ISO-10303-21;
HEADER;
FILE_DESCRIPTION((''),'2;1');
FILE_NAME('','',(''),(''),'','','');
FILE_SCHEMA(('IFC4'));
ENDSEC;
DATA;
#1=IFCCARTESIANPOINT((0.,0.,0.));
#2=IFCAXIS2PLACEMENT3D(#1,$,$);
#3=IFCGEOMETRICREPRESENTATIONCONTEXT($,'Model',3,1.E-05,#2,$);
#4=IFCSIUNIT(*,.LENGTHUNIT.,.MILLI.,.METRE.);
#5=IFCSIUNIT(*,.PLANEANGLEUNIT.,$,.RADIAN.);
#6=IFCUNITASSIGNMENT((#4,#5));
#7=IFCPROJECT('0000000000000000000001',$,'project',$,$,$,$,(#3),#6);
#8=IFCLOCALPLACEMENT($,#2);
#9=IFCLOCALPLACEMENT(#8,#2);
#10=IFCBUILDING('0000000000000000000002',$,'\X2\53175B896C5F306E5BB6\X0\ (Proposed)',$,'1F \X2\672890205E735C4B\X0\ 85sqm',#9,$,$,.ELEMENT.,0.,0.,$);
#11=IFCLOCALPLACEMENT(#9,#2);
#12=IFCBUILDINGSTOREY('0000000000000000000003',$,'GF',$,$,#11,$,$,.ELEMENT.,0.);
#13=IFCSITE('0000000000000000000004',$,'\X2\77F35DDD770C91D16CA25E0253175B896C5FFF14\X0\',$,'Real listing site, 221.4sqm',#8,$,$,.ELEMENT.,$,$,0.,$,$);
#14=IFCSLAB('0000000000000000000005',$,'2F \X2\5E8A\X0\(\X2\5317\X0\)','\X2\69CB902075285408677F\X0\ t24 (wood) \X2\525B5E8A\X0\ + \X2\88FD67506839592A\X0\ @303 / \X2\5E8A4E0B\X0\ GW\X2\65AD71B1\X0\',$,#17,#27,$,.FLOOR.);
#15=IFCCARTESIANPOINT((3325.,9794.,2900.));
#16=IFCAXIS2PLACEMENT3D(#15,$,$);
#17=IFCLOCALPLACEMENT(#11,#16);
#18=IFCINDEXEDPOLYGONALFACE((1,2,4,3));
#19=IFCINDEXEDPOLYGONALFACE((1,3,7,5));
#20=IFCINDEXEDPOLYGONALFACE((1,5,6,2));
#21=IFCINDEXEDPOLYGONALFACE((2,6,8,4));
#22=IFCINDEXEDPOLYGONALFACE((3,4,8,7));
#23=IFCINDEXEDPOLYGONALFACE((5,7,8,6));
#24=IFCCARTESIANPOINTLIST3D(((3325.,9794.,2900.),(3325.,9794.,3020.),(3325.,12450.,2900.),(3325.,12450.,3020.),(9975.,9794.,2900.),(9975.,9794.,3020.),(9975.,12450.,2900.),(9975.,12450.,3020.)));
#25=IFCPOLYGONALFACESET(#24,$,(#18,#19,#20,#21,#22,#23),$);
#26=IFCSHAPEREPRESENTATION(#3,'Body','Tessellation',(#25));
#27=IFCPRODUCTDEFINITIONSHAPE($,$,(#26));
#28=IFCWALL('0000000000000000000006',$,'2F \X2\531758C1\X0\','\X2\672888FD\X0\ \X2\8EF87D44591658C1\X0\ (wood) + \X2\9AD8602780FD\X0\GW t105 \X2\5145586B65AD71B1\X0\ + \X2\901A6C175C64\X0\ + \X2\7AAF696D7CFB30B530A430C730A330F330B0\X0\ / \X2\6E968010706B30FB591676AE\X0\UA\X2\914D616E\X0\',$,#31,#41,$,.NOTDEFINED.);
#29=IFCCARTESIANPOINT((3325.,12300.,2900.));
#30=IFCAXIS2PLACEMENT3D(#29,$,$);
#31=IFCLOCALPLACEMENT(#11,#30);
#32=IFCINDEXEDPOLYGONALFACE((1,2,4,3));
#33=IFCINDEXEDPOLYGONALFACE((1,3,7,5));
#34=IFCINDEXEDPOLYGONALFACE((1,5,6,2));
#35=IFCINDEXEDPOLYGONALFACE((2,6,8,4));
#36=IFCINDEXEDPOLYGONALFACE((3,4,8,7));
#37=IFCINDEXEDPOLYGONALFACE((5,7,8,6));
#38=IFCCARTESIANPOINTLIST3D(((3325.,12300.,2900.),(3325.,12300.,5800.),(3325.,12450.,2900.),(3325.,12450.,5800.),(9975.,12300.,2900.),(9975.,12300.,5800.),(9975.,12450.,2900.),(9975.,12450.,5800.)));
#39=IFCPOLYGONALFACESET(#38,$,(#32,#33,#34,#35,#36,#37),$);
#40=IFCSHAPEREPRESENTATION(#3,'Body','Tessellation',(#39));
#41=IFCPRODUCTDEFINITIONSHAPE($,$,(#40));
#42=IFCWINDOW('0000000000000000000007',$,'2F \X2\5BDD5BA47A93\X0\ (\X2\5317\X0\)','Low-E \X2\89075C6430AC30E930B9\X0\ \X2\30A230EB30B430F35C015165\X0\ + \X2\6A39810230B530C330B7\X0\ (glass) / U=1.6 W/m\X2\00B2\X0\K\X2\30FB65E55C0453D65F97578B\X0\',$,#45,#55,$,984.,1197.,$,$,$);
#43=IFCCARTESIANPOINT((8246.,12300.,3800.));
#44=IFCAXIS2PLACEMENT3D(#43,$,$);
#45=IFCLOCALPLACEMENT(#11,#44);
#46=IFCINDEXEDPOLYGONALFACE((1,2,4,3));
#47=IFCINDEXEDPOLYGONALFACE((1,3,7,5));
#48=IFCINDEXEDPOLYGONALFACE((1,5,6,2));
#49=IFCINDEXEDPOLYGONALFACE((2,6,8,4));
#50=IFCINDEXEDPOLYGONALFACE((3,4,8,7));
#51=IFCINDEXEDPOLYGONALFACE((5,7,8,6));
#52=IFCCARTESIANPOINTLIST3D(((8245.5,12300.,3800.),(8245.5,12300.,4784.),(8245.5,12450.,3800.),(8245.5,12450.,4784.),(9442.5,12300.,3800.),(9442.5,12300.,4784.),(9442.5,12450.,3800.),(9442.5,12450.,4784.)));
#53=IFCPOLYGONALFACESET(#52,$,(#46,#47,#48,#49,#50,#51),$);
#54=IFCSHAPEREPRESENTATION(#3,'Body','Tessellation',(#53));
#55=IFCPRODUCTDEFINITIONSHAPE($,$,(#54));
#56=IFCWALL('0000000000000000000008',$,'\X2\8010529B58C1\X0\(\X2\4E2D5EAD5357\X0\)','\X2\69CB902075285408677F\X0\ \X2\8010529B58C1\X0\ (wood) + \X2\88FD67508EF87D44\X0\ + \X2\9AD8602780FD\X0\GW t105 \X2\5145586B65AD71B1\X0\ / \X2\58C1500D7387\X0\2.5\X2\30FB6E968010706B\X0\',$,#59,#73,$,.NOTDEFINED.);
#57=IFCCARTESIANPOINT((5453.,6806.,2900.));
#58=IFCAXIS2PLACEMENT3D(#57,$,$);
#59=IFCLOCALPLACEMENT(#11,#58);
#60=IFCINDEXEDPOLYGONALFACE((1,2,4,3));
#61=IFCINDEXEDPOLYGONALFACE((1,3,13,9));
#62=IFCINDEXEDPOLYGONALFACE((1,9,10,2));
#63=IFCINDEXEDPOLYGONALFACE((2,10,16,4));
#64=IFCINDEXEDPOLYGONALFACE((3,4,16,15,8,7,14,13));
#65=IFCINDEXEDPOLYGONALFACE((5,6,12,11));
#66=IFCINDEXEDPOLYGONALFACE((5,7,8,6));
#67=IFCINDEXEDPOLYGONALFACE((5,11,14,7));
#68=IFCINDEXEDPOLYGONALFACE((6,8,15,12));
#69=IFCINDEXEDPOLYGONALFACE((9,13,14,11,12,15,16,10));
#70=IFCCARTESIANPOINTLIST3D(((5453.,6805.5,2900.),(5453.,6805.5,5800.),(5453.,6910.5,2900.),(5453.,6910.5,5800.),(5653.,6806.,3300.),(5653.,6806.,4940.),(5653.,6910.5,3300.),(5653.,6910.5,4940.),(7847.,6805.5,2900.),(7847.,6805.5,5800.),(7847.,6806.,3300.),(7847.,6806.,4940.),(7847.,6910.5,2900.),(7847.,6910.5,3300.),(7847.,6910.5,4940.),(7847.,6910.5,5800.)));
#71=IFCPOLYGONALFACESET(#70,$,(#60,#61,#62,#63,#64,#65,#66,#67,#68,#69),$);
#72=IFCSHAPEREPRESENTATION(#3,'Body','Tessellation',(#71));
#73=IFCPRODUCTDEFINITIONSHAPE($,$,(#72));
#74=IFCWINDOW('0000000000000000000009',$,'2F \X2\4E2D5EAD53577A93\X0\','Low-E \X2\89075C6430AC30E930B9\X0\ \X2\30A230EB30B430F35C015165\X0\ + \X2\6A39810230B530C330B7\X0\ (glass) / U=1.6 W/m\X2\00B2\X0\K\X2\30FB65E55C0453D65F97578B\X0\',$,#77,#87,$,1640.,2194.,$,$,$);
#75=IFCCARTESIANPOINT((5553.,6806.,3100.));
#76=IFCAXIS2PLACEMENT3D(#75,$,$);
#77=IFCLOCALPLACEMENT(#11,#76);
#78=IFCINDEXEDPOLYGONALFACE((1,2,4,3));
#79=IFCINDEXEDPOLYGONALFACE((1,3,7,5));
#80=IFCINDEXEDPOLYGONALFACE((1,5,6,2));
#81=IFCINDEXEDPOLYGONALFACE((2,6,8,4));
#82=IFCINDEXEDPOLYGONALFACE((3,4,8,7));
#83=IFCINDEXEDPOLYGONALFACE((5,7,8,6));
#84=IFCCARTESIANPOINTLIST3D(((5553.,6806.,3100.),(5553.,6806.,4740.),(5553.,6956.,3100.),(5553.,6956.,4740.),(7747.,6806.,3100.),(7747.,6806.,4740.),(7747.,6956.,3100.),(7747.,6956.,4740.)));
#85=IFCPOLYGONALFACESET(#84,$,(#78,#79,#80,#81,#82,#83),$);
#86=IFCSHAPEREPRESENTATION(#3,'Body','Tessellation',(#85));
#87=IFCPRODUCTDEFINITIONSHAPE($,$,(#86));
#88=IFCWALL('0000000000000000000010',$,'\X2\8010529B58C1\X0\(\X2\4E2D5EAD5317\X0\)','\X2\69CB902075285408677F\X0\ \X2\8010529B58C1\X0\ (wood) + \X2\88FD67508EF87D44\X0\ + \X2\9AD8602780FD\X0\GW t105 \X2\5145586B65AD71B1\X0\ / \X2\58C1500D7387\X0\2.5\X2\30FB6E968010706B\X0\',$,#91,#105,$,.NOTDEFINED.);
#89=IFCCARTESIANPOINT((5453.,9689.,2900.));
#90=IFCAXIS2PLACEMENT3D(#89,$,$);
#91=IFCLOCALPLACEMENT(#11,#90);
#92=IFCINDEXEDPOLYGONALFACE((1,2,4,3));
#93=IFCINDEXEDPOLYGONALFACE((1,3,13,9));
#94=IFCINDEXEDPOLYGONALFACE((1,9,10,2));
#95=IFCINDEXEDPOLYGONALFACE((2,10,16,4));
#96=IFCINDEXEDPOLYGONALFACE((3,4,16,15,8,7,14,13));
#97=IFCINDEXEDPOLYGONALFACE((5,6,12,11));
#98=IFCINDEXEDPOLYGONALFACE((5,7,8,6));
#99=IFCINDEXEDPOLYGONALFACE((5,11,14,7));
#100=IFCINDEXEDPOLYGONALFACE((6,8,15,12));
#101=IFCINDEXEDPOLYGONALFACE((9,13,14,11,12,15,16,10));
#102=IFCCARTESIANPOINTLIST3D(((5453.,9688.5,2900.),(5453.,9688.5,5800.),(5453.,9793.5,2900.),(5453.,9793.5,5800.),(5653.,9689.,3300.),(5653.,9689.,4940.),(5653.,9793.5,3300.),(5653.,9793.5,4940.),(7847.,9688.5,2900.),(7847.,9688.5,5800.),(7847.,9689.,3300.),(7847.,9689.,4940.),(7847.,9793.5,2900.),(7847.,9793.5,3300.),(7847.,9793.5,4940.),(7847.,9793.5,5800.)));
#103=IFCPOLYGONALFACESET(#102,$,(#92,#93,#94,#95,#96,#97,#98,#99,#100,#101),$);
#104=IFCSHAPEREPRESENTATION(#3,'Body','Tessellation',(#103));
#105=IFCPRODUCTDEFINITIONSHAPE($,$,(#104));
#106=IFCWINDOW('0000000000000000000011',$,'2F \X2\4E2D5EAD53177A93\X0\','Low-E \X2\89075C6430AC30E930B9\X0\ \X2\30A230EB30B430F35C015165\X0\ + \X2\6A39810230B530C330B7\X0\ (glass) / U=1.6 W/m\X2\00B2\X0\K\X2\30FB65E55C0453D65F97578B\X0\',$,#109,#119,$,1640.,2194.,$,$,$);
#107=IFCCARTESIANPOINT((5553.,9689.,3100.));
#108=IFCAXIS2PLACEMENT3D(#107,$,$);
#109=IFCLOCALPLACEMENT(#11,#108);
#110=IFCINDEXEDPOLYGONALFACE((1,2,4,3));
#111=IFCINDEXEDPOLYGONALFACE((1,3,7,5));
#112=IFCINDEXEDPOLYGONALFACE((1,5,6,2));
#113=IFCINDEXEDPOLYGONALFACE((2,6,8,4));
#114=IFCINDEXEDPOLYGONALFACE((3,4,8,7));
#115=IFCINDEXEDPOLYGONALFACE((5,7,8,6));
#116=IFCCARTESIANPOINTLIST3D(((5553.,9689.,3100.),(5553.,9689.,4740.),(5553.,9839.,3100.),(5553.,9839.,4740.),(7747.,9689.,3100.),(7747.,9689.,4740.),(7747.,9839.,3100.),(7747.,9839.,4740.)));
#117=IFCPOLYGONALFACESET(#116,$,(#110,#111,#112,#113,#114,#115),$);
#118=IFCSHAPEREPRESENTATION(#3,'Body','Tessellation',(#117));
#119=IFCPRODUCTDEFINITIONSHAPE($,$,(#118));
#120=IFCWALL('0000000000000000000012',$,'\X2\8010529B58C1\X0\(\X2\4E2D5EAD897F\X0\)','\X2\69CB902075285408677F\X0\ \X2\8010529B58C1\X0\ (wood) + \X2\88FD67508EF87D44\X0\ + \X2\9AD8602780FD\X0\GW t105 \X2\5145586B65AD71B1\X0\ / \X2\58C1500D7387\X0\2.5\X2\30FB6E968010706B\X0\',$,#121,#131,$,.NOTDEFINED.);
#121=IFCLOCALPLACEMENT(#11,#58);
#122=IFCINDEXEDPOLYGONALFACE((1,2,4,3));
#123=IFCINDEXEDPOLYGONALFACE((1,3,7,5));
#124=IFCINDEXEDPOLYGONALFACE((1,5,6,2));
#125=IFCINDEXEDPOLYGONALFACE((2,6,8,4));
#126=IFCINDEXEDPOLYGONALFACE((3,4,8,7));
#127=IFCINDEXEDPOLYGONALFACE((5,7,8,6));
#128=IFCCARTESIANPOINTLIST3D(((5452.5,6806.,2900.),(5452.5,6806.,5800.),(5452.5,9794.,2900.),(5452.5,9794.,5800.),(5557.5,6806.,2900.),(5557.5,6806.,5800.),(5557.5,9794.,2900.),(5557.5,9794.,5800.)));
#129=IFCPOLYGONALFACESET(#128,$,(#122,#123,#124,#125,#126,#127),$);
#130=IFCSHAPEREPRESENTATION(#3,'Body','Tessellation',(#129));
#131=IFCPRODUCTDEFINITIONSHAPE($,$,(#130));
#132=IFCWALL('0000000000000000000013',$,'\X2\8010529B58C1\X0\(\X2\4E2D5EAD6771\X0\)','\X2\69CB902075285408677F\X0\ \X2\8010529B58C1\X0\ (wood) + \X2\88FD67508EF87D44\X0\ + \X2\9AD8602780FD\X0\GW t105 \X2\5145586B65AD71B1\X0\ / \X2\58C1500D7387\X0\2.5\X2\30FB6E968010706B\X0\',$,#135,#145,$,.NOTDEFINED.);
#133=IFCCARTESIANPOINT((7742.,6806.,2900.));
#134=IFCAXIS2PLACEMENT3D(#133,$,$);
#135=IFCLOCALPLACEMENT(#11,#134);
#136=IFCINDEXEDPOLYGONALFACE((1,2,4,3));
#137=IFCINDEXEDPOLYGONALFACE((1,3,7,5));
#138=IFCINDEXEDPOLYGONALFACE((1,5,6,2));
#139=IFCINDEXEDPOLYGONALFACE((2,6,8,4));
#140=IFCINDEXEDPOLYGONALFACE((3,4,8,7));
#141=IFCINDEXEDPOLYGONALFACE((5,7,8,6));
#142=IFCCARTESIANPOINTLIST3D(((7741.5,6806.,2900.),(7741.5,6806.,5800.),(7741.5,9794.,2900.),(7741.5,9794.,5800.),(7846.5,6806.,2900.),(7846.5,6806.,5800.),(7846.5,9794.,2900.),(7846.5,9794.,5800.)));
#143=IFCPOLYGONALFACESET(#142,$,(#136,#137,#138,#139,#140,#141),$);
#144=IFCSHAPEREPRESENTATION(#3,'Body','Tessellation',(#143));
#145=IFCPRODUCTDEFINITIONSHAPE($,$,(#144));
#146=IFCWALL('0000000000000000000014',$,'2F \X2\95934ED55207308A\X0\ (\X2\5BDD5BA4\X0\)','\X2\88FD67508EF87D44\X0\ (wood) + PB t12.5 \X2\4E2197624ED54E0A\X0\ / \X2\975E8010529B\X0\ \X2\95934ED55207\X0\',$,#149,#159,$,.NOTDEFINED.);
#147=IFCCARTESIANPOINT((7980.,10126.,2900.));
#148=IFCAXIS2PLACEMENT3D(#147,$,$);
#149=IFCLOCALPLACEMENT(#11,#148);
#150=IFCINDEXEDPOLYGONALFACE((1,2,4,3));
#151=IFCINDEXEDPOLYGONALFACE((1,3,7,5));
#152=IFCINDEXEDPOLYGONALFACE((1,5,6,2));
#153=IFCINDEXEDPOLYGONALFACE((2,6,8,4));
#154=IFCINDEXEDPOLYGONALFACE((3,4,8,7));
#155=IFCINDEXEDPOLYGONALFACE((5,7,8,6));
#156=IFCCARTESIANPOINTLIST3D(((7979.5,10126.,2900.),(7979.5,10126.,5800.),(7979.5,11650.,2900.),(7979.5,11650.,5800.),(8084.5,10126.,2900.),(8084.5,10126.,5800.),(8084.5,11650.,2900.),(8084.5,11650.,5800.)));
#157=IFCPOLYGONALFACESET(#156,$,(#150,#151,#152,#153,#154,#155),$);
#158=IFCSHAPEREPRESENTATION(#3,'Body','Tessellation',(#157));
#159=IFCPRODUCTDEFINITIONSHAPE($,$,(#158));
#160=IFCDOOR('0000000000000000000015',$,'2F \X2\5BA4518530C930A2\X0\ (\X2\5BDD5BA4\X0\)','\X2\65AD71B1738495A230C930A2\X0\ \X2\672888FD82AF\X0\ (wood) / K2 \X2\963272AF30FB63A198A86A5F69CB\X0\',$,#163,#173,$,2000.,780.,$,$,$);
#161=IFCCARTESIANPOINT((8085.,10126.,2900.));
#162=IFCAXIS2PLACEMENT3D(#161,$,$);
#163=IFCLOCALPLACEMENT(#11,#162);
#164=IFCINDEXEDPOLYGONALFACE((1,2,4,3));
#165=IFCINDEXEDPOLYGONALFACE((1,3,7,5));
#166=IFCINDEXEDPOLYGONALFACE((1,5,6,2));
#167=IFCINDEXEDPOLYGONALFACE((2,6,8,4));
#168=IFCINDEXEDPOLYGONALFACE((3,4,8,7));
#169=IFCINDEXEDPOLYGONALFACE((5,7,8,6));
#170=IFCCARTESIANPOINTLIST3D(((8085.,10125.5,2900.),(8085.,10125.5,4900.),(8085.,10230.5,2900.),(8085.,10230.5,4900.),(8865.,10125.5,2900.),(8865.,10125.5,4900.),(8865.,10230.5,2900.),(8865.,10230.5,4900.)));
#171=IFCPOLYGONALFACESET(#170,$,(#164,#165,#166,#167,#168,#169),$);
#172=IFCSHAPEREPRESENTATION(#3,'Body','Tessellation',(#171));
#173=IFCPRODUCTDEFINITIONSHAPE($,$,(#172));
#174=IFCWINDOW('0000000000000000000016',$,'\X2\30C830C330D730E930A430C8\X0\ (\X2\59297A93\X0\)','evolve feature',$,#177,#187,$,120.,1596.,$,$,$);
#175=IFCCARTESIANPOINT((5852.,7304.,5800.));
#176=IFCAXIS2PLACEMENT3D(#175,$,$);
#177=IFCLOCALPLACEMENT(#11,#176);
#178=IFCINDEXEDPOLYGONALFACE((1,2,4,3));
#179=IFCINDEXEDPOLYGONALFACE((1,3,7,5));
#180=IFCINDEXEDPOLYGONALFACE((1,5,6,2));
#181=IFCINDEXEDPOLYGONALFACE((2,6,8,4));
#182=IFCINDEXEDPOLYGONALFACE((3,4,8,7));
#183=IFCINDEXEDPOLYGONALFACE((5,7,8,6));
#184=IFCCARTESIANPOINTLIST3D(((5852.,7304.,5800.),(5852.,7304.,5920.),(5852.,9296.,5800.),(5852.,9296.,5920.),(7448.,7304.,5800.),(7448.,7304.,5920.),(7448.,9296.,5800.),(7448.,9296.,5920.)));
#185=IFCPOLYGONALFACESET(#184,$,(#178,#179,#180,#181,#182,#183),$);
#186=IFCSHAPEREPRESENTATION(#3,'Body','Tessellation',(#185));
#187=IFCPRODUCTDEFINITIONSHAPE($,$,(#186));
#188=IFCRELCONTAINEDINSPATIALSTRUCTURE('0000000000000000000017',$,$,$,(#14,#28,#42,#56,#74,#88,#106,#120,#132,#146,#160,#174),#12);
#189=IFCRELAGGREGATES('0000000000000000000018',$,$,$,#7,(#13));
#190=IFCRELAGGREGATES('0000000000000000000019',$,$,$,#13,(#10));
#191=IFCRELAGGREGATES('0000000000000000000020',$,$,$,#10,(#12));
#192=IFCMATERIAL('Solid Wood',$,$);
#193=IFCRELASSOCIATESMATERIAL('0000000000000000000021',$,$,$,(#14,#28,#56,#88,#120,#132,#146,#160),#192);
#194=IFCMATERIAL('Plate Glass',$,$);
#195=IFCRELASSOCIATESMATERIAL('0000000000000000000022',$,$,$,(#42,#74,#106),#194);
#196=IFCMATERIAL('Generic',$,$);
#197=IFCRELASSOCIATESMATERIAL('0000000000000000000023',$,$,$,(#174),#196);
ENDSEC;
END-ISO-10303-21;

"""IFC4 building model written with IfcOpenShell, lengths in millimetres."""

from ifc_helpers import new_model, si_unit, frame, frame_2d, origin, place, context, project, spatial, rectangle, extrude, material, element, fill, save


model = new_model("IFC4")

# Units and contexts
model_context = context("Model", 3, precision=1e-05, world=origin())
ifc_project = project(units=[si_unit("LENGTHUNIT", "METRE", prefix="MILLI"), si_unit("PLANEANGLEUNIT", "RADIAN")], contexts=[model_context])

# Site, building, storey
site_placement = place(None, origin())
site = spatial("IfcSite", under=ifc_project, at=site_placement, Name="石川県金沢市北安江４", ObjectType="Real listing site, 221.4sqm", CompositionType="ELEMENT", RefElevation=0.0)
building_placement = place(site_placement, origin())
building = spatial("IfcBuilding", under=site, at=building_placement, Name="北安江の家 (Proposed)", ObjectType="1F 木造平屋 85sqm", CompositionType="ELEMENT", ElevationOfRefHeight=0.0, ElevationOfTerrain=0.0)
storey_placement = place(building_placement, origin())
storey = spatial("IfcBuildingStorey", under=building, at=storey_placement, Name="GF", CompositionType="ELEMENT", Elevation=0.0)

# Slab
ifc_material_1 = material(Name="Solid Wood")
slab_placement = place(storey_placement, frame((3325.0, 9794.0, 2900.0)))
element("IfcSlab", 1, at=slab_placement, inside=storey, material=ifc_material_1, Name="2F 床(北)", Description="構造用合板 t24 (wood) 剛床 + 製材根太 @303 / 床下 GW断熱", PredefinedType="FLOOR", context=model_context, shape_type="SweptSolid", body=[
    extrude(rectangle(XDim=6650.0, YDim=2656.0, at=frame_2d((3325.0, 1328.0))), frame((3325.0, 9794.0, 2900.0)), (0.0, 0.0, 1.0), 120.0),
])

# Walls, openings, windows
wall_1_placement = place(storey_placement, frame((3325.0, 12300.0, 2900.0)))
wall_1 = element("IfcWall", 2, at=wall_1_placement, inside=storey, material=ifc_material_1, Name="2F 北壁", Description="木製 軸組外壁 (wood) + 高性能GW t105 充填断熱 + 通気層 + 窯業系サイディング / 準耐火・外皮UA配慮", PredefinedType="NOTDEFINED", context=model_context, shape_type="SweptSolid", body=[
    extrude(rectangle(XDim=6650.0, YDim=150.0, at=frame_2d((3325.0, 75.0))), frame((3325.0, 12300.0, 2900.0)), (0.0, 0.0, 1.0), 2900.0),
])
opening_1_placement = place(storey_placement, frame((8246.0, 12300.0, 3800.0)))
opening_1 = element("IfcOpeningElement", 3, at=opening_1_placement, cuts=wall_1, PredefinedType="NOTDEFINED", context=model_context, shape_type="SweptSolid", body=[
    extrude(rectangle(XDim=1197.0, YDim=150.0, at=frame_2d((598.0, 75.0))), frame((8246.0, 12300.0, 3800.0)), (0.0, 0.0, 1.0), 984.0),
])
ifc_material_2 = material(Name="Plate Glass")
window_1_placement = place(storey_placement, frame((8246.0, 12300.0, 3800.0)))
window_1 = element("IfcWindow", 4, at=window_1_placement, inside=storey, material=ifc_material_2, Name="2F 寝室窓 (北)", Description="Low-E 複層ガラス アルゴン封入 + 樹脂サッシ (glass) / U=1.6 W/m²K・日射取得型", OverallHeight=984.0, OverallWidth=1197.0, context=model_context, shape_type="SweptSolid", body=[
    extrude(rectangle(XDim=1197.0, YDim=150.0, at=frame_2d((598.0, 75.0))), frame((8246.0, 12300.0, 3800.0)), (0.0, 0.0, 1.0), 984.0),
])
fill(opening_1, window_1)
wall_2_placement = place(storey_placement, frame((5453.0, 6806.0, 2900.0)))
wall_2 = element("IfcWall", 5, at=wall_2_placement, inside=storey, material=ifc_material_1, Name="耐力壁(中庭南)", Description="構造用合板 耐力壁 (wood) + 製材軸組 + 高性能GW t105 充填断熱 / 壁倍率2.5・準耐火", PredefinedType="NOTDEFINED", context=model_context, shape_type="SweptSolid", body=[
    extrude(rectangle(XDim=2394.0, YDim=105.0, at=frame_2d((1197.0, 52.0))), frame((5453.0, 6806.0, 2900.0)), (0.0, 0.0, 1.0), 2900.0),
])
opening_2_placement = place(storey_placement, frame((5553.0, 6806.0, 3100.0)))
opening_2 = element("IfcOpeningElement", 6, at=opening_2_placement, cuts=wall_2, PredefinedType="NOTDEFINED", context=model_context, shape_type="SweptSolid", body=[
    extrude(rectangle(XDim=2194.0, YDim=150.0, at=frame_2d((1097.0, 75.0))), frame((5553.0, 6806.0, 3100.0)), (0.0, 0.0, 1.0), 1640.0),
])
window_2_placement = place(storey_placement, frame((5553.0, 6806.0, 3100.0)))
window_2 = element("IfcWindow", 7, at=window_2_placement, inside=storey, material=ifc_material_2, Name="2F 中庭南窓", Description="Low-E 複層ガラス アルゴン封入 + 樹脂サッシ (glass) / U=1.6 W/m²K・日射取得型", OverallHeight=1640.0, OverallWidth=2194.0, context=model_context, shape_type="SweptSolid", body=[
    extrude(rectangle(XDim=2194.0, YDim=150.0, at=frame_2d((1097.0, 75.0))), frame((5553.0, 6806.0, 3100.0)), (0.0, 0.0, 1.0), 1640.0),
])
fill(opening_2, window_2)
wall_3_placement = place(storey_placement, frame((5453.0, 9689.0, 2900.0)))
wall_3 = element("IfcWall", 8, at=wall_3_placement, inside=storey, material=ifc_material_1, Name="耐力壁(中庭北)", Description="構造用合板 耐力壁 (wood) + 製材軸組 + 高性能GW t105 充填断熱 / 壁倍率2.5・準耐火", PredefinedType="NOTDEFINED", context=model_context, shape_type="SweptSolid", body=[
    extrude(rectangle(XDim=2394.0, YDim=105.0, at=frame_2d((1197.0, 52.0))), frame((5453.0, 9689.0, 2900.0)), (0.0, 0.0, 1.0), 2900.0),
])
opening_3_placement = place(storey_placement, frame((5553.0, 9689.0, 3100.0)))
opening_3 = element("IfcOpeningElement", 9, at=opening_3_placement, cuts=wall_3, PredefinedType="NOTDEFINED", context=model_context, shape_type="SweptSolid", body=[
    extrude(rectangle(XDim=2194.0, YDim=150.0, at=frame_2d((1097.0, 75.0))), frame((5553.0, 9689.0, 3100.0)), (0.0, 0.0, 1.0), 1640.0),
])
window_3_placement = place(storey_placement, frame((5553.0, 9689.0, 3100.0)))
window_3 = element("IfcWindow", 10, at=window_3_placement, inside=storey, material=ifc_material_2, Name="2F 中庭北窓", Description="Low-E 複層ガラス アルゴン封入 + 樹脂サッシ (glass) / U=1.6 W/m²K・日射取得型", OverallHeight=1640.0, OverallWidth=2194.0, context=model_context, shape_type="SweptSolid", body=[
    extrude(rectangle(XDim=2194.0, YDim=150.0, at=frame_2d((1097.0, 75.0))), frame((5553.0, 9689.0, 3100.0)), (0.0, 0.0, 1.0), 1640.0),
])
fill(opening_3, window_3)

# Walls
wall_4_placement = place(storey_placement, frame((5453.0, 6806.0, 2900.0)))
element("IfcWall", 11, at=wall_4_placement, inside=storey, material=ifc_material_1, Name="耐力壁(中庭西)", Description="構造用合板 耐力壁 (wood) + 製材軸組 + 高性能GW t105 充填断熱 / 壁倍率2.5・準耐火", PredefinedType="NOTDEFINED", context=model_context, shape_type="SweptSolid", body=[
    extrude(rectangle(XDim=105.0, YDim=2988.0, at=frame_2d((52.0, 1494.0))), frame((5453.0, 6806.0, 2900.0)), (0.0, 0.0, 1.0), 2900.0),
])
wall_5_placement = place(storey_placement, frame((7742.0, 6806.0, 2900.0)))
element("IfcWall", 12, at=wall_5_placement, inside=storey, material=ifc_material_1, Name="耐力壁(中庭東)", Description="構造用合板 耐力壁 (wood) + 製材軸組 + 高性能GW t105 充填断熱 / 壁倍率2.5・準耐火", PredefinedType="NOTDEFINED", context=model_context, shape_type="SweptSolid", body=[
    extrude(rectangle(XDim=105.0, YDim=2988.0, at=frame_2d((52.0, 1494.0))), frame((7742.0, 6806.0, 2900.0)), (0.0, 0.0, 1.0), 2900.0),
])
wall_6_placement = place(storey_placement, frame((7980.0, 10126.0, 2900.0)))
element("IfcWall", 13, at=wall_6_placement, inside=storey, material=ifc_material_1, Name="2F 間仕切り (寝室)", Description="製材軸組 (wood) + PB t12.5 両面仕上 / 非耐力 間仕切", PredefinedType="NOTDEFINED", context=model_context, shape_type="SweptSolid", body=[
    extrude(rectangle(XDim=105.0, YDim=1524.0, at=frame_2d((52.0, 762.0))), frame((7980.0, 10126.0, 2900.0)), (0.0, 0.0, 1.0), 2900.0),
])

# Door
door_placement = place(storey_placement, frame((8085.0, 10126.0, 2900.0)))
element("IfcDoor", 14, at=door_placement, inside=storey, material=ifc_material_1, Name="2F 室内ドア (寝室)", Description="断熱玄関ドア 木製芯 (wood) / K2 防犯・採風機構", OverallHeight=2000.0, OverallWidth=780.0, context=model_context, shape_type="SweptSolid", body=[
    extrude(rectangle(XDim=780.0, YDim=105.0, at=frame_2d((390.0, 52.0))), frame((8085.0, 10126.0, 2900.0)), (0.0, 0.0, 1.0), 2000.0),
])

# Window
ifc_material_3 = material(Name="Generic")
window_4_placement = place(storey_placement, frame((5852.0, 7304.0, 5800.0)))
element("IfcWindow", 15, at=window_4_placement, inside=storey, material=ifc_material_3, Name="トップライト (天窓)", Description="evolve feature", OverallHeight=120.0, OverallWidth=1596.0, context=model_context, shape_type="SweptSolid", body=[
    extrude(rectangle(XDim=1596.0, YDim=1992.0, at=frame_2d((798.0, 996.0))), frame((5852.0, 7304.0, 5800.0)), (0.0, 0.0, 1.0), 120.0),
])

save(model, "model.ifc")
